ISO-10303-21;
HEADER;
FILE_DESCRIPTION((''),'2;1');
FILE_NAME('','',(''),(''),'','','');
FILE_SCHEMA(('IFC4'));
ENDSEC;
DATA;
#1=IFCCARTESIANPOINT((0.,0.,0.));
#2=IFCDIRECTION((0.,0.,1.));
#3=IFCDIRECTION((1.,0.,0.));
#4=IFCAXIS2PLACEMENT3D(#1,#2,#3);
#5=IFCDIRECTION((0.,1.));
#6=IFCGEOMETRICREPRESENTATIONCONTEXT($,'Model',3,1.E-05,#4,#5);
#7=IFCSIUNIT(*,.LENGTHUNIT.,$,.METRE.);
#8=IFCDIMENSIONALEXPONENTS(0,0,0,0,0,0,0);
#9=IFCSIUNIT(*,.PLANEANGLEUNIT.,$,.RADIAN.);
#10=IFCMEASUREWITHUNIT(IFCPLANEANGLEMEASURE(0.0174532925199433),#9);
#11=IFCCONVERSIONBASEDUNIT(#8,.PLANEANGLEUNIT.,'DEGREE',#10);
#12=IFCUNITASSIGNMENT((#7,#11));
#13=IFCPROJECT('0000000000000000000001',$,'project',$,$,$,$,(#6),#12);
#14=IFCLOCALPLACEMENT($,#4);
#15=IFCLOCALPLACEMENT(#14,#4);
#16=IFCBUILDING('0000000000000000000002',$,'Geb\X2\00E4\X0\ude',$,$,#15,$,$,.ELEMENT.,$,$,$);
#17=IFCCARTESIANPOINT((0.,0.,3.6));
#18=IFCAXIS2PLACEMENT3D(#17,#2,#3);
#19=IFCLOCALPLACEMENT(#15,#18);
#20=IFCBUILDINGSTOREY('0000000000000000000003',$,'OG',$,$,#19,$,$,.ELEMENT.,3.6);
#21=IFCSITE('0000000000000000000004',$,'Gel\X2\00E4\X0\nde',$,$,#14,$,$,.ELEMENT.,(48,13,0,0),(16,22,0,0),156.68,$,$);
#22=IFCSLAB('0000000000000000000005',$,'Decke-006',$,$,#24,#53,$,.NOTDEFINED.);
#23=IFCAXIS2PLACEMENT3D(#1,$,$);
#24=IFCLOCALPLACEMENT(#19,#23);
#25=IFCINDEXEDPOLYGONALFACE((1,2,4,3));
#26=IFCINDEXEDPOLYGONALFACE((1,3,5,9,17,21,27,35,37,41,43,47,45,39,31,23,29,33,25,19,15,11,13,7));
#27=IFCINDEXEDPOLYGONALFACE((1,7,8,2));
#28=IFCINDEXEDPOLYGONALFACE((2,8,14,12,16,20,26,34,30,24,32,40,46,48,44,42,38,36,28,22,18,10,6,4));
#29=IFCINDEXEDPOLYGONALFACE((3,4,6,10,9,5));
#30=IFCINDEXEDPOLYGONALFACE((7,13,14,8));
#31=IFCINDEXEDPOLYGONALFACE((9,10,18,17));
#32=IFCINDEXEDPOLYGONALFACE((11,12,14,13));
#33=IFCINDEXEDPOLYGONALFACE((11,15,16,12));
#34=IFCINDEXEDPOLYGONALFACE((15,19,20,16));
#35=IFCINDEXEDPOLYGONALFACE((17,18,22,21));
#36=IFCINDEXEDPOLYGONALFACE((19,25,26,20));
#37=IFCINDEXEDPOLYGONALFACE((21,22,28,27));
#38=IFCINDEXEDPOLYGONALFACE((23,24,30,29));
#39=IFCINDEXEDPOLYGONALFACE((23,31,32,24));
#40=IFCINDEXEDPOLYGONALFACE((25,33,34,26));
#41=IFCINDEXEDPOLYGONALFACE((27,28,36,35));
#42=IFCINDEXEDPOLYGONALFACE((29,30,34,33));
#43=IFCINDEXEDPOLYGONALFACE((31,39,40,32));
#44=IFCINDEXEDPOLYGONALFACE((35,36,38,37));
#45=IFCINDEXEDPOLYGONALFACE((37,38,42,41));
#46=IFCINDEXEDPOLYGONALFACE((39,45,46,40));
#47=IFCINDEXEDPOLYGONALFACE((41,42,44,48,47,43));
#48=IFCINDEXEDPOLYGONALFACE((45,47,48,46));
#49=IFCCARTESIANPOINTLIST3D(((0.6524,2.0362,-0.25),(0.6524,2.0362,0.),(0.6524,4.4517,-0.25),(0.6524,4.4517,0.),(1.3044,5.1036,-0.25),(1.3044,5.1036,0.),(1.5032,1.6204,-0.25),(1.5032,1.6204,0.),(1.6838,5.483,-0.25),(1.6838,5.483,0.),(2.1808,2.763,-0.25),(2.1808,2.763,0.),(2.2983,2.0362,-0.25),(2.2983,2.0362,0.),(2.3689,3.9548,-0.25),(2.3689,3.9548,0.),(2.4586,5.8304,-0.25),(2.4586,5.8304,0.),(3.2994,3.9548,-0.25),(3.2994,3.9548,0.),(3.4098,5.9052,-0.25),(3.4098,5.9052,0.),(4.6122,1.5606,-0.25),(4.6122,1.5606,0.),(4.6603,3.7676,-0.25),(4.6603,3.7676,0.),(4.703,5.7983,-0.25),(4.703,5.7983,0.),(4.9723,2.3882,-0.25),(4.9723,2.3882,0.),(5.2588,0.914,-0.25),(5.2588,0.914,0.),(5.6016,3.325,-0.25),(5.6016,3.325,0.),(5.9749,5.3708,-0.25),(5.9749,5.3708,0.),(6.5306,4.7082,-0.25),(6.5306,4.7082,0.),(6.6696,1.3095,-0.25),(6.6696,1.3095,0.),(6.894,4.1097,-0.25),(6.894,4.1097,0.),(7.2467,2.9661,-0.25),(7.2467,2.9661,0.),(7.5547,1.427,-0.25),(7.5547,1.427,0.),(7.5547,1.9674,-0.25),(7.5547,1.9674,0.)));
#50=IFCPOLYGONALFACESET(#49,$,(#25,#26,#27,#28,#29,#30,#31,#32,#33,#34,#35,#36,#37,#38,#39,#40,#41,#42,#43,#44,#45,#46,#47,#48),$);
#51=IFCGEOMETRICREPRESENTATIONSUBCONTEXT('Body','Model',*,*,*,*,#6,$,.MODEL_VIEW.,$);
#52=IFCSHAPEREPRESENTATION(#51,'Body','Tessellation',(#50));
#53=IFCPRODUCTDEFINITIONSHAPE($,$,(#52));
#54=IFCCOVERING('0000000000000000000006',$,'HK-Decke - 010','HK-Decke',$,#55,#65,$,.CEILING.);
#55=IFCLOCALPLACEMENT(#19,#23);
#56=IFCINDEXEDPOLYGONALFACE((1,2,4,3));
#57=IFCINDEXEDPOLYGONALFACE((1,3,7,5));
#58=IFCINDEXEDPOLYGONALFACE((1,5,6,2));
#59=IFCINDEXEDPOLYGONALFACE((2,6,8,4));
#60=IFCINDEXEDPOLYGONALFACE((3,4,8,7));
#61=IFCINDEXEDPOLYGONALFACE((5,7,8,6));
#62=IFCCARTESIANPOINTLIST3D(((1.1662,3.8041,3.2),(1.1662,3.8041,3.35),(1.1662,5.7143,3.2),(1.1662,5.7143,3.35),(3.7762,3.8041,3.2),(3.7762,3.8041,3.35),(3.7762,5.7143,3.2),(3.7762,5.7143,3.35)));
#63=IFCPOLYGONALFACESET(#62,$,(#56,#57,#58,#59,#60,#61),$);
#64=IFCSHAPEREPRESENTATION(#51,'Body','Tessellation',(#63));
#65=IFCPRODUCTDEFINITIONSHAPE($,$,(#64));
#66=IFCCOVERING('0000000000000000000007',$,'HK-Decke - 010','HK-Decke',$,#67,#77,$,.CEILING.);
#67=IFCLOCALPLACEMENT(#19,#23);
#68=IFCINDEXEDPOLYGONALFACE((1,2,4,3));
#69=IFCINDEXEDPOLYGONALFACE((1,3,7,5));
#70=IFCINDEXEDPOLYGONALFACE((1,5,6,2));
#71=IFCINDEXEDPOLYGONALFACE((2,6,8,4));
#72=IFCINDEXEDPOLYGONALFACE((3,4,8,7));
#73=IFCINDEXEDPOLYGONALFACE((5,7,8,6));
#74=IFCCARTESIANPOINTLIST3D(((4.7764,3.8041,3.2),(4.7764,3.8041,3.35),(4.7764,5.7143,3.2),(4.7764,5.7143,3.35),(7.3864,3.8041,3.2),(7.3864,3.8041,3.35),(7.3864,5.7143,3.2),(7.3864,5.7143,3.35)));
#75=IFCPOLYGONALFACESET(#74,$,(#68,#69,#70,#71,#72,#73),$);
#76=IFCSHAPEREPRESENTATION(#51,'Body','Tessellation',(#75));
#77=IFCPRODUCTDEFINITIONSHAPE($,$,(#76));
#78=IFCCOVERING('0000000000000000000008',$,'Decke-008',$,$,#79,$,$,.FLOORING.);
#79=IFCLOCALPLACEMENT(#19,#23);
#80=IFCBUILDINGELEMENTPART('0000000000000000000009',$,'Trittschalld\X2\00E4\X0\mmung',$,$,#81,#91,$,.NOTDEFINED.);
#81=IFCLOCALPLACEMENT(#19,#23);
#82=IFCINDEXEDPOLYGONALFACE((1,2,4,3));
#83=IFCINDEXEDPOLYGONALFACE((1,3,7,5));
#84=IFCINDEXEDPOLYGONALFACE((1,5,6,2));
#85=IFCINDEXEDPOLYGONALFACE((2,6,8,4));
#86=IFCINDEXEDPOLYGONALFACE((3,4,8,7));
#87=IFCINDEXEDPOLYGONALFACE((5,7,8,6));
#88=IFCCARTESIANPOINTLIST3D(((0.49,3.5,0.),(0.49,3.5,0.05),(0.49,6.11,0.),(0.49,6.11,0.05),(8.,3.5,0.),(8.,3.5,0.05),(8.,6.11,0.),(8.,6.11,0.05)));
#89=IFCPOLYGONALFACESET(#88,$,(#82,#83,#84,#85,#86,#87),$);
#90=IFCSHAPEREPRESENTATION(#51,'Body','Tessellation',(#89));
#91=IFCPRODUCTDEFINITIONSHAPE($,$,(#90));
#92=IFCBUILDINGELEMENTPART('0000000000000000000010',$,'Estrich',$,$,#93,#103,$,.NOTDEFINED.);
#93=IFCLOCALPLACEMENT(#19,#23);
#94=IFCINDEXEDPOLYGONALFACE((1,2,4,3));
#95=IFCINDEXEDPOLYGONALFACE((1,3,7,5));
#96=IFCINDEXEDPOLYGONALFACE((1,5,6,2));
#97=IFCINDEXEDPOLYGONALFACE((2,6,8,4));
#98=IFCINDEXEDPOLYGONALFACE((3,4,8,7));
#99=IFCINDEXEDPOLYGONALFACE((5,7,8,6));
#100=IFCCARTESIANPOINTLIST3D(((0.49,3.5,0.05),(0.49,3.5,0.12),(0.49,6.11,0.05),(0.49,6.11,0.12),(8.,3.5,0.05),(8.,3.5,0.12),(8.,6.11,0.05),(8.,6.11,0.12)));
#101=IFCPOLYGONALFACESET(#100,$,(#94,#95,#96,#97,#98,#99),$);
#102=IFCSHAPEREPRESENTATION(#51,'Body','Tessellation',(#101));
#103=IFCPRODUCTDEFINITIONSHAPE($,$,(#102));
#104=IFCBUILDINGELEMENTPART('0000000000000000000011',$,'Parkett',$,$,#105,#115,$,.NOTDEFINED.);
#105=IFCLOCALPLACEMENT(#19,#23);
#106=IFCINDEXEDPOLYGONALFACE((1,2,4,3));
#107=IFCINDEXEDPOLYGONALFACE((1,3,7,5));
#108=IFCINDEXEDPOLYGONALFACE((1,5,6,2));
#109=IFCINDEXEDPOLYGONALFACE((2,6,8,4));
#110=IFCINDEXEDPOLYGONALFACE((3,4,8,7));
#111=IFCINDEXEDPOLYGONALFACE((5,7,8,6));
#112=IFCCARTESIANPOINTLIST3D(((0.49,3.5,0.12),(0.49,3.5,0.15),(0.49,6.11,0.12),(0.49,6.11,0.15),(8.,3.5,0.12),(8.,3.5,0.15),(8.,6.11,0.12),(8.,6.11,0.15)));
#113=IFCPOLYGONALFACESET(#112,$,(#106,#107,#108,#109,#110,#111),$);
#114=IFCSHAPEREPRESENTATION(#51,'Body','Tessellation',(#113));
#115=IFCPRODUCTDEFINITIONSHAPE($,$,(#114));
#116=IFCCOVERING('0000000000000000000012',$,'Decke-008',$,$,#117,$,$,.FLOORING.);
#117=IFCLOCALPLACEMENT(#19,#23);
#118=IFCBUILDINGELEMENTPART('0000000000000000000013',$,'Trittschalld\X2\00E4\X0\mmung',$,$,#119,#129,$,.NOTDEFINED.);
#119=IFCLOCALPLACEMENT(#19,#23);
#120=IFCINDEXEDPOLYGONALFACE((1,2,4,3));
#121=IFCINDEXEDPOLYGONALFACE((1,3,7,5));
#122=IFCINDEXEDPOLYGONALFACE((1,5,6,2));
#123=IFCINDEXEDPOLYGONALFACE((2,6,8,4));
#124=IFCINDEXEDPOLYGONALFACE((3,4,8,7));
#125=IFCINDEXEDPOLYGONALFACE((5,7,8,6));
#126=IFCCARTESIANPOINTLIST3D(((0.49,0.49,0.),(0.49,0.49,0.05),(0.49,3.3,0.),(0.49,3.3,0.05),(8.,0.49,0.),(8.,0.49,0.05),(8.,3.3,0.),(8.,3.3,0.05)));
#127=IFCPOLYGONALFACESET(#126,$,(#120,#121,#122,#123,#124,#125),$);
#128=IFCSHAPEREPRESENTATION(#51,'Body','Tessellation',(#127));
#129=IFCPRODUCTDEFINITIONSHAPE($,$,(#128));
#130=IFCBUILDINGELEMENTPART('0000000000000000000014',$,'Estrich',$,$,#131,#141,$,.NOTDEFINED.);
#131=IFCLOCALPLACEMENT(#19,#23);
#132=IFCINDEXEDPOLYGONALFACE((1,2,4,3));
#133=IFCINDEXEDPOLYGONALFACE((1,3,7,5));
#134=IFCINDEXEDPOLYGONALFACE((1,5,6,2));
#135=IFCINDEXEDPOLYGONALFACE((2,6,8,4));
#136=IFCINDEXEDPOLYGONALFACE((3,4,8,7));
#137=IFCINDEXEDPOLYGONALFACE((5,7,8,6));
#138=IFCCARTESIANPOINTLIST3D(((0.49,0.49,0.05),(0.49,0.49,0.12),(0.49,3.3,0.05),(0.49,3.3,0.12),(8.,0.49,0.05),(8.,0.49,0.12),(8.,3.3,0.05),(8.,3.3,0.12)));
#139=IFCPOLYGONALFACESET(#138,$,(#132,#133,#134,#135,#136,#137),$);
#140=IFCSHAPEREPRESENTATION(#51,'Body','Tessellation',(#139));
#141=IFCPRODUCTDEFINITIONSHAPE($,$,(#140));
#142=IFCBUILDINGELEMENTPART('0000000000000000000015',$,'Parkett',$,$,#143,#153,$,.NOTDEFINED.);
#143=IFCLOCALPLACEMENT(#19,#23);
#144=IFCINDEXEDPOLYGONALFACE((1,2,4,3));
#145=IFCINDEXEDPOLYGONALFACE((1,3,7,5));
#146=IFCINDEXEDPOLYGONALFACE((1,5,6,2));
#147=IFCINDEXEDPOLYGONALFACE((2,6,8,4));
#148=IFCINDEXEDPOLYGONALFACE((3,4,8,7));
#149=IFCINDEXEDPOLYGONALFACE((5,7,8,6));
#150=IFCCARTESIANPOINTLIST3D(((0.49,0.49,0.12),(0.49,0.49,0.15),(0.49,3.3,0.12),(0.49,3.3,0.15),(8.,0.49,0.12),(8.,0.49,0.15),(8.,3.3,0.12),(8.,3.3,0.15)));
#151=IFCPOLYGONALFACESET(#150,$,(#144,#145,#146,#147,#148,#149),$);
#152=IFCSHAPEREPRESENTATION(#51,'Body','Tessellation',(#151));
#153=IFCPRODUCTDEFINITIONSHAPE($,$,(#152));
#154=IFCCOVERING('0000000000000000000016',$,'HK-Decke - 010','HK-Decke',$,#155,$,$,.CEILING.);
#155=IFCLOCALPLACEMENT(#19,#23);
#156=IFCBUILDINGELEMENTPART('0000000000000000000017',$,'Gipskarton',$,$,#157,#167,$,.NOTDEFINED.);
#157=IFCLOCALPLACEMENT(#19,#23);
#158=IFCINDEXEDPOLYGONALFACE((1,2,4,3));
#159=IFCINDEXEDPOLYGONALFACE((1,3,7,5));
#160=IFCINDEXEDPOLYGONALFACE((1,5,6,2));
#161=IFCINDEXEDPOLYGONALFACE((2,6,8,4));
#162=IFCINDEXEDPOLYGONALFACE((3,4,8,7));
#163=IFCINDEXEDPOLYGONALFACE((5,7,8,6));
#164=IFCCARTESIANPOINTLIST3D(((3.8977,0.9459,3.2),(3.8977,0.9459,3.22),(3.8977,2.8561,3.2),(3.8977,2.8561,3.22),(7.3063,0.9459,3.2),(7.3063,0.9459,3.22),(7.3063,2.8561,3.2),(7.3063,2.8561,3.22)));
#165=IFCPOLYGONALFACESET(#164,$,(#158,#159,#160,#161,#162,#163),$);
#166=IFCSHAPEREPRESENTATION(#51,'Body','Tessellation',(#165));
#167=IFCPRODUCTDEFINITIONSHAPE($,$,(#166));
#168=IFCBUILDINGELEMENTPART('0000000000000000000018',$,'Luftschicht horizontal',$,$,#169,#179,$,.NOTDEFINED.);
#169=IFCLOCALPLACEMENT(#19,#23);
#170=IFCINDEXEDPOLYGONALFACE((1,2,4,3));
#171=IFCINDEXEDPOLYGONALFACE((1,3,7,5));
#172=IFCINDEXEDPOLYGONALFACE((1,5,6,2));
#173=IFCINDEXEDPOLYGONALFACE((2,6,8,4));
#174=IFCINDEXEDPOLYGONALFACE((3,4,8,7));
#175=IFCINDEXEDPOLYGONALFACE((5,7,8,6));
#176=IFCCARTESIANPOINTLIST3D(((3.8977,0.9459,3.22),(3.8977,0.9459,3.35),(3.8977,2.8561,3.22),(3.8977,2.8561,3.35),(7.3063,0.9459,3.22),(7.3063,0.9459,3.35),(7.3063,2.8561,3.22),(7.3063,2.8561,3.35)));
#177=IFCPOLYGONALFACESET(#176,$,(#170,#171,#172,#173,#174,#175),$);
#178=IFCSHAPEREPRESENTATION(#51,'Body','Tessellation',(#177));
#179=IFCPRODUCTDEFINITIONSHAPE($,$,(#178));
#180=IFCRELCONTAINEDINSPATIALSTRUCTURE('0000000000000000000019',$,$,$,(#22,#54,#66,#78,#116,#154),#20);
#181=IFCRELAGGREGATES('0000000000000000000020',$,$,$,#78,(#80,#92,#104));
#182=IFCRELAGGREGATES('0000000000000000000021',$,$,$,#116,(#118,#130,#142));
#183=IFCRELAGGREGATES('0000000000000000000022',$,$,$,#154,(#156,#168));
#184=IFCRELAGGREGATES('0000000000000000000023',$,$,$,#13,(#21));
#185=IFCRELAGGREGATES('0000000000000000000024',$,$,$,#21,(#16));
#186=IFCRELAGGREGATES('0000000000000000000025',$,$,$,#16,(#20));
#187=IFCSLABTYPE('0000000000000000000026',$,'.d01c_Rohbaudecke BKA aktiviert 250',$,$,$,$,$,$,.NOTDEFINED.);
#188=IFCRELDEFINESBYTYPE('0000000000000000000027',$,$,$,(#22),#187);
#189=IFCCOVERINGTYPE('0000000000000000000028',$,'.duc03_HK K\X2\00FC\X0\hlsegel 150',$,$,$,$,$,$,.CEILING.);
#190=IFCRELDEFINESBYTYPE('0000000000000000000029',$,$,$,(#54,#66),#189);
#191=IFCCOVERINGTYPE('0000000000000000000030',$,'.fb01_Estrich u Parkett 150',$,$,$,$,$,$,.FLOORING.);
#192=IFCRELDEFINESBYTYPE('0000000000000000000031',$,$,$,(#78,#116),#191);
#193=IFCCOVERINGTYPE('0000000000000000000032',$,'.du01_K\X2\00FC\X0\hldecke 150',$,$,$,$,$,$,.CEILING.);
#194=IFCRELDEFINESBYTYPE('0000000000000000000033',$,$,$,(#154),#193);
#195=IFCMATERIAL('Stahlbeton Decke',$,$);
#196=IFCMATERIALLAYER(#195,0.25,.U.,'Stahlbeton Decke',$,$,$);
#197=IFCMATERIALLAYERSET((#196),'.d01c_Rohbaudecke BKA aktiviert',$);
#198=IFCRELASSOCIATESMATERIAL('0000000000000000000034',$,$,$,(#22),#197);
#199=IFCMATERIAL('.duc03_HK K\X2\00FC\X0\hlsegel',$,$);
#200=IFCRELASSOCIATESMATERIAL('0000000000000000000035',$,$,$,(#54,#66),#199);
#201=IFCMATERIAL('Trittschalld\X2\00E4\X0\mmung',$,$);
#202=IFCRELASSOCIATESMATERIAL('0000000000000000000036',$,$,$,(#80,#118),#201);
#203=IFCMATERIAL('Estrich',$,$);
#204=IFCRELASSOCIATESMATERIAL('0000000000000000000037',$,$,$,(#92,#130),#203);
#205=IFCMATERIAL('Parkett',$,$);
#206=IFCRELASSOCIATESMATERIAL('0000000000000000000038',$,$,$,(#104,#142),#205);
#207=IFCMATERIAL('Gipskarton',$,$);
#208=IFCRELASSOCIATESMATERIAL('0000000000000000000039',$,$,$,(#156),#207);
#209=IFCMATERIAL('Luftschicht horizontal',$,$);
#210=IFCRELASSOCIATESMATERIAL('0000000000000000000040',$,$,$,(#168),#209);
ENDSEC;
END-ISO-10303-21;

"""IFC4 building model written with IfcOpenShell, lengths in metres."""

from ifc_helpers import new_model, entity, si_unit, converted_unit, direction, frame, origin_with_axes, place, context, subcontext, project, spatial, line, indexed_curve, outline, extrude, material, layer, layer_set, layer_usage, type_object, element, aggregate, save


model = new_model("IFC4")

# Units and contexts
model_context = context("Model", 3, precision=1e-05, world=origin_with_axes(), true_north=direction((0.0, 1.0)))
body_context = subcontext(model_context, "Body", "Model", "MODEL_VIEW")
ifc_project = project(units=[si_unit("LENGTHUNIT", "METRE"), converted_unit("PLANEANGLEUNIT", "DEGREE", entity("IfcPlaneAngleMeasure", 0.0174532925199433), si_unit("PLANEANGLEUNIT", "RADIAN"), dimensions=[0, 0, 0, 0, 0, 0, 0])], contexts=[model_context])

# Site, building, storey
site_placement = place(None, origin_with_axes())
site = spatial("IfcSite", under=ifc_project, at=site_placement, Name="Gelände", CompositionType="ELEMENT", RefLatitude=(48, 13, 0, 0), RefLongitude=(16, 22, 0, 0), RefElevation=156.68)
building_placement = place(site_placement, origin_with_axes())
building = spatial("IfcBuilding", under=site, at=building_placement, Name="Gebäude", CompositionType="ELEMENT")
storey_placement = place(building_placement, frame((0.0, 0.0, 3.6), z_axis=(0.0, 0.0, 1.0), x_axis=(1.0, 0.0, 0.0)))
storey = spatial("IfcBuildingStorey", under=building, at=storey_placement, Name="OG", CompositionType="ELEMENT", Elevation=3.6)

# Slab
ifc_material_1 = material(Name="Stahlbeton Decke")
ifc_layer = layer(ifc_material_1, 0.25, ventilated="UNKNOWN", Name="Stahlbeton Decke")
ifc_layer_set = layer_set([ifc_layer], Name=".d01c_Rohbaudecke BKA aktiviert")
ifc_layer_usage = layer_usage(ifc_layer_set, "AXIS3", "NEGATIVE", 0.25)
slab_type = type_object("IfcSlabType", Name=".d01c_Rohbaudecke BKA aktiviert 250", PredefinedType="NOTDEFINED")
slab_placement = place(storey_placement, frame((1.3044, 5.1036, 0.0), z_axis=(0.0, 0.0, 1.0), x_axis=(1.0, 0.0, 0.0)))
element("IfcSlab", 1, at=slab_placement, inside=storey, type_object=slab_type, material=ifc_layer_usage, Name="Decke-006", PredefinedType="NOTDEFINED", context=body_context, shape_type="SweptSolid", body=[
    extrude(outline(indexed_curve([(0.0, 0.0), (-0.6519, -0.6519), (-0.6519, -3.0674), (0.1988, -3.4832), (0.994, -3.0674), (0.8764, -2.3406), (1.0645, -1.1488), (1.9951, -1.1488), (3.3559, -1.336), (4.2972, -1.7786), (3.6679, -2.7155), (3.3078, -3.543), (3.9544, -4.1896), (5.3652, -3.7941), (6.2503, -3.6766), (6.2503, -3.1362), (5.9423, -2.1375), (5.5896, -0.994), (5.2263, -0.3954), (4.6705, 0.2672), (3.3987, 0.6947), (2.1055, 0.8016), (1.1543, 0.7268), (0.3794, 0.3794)], segments=[line(1, 2, 3, 4, 5, 6, 7, 8, 9, 10, 11, 12, 13, 14, 15, 16, 17, 18, 19, 20, 21, 22, 23, 24, 1)])), frame((0.0, 0.0, -0.25), z_axis=(0.0, 0.0, 1.0), x_axis=(1.0, 0.0, 0.0)), (0.0, 0.0, 1.0), 0.25),
])

# Coverings
ifc_material_2 = material(Name=".duc03_HK Kühlsegel")
covering_type_1 = type_object("IfcCoveringType", Name=".duc03_HK Kühlsegel 150", PredefinedType="CEILING")
for number, where, z_axis, x_axis, name in (
    (2, (1.1662, 5.7143, 3.35), (0.0, 0.0, 1.0), (1.0, 0.0, 0.0), "HK-Decke - 010"),
    (3, (4.7764, 5.7143, 3.35), (0.0, 0.0, 1.0), (1.0, 0.0, 0.0), "HK-Decke - 010"),
):
    element("IfcCovering", number, at=place(storey_placement, frame(where, z_axis=z_axis, x_axis=x_axis)), inside=storey, type_object=covering_type_1, material=ifc_material_2, Name=name, Description="HK-Decke", PredefinedType="CEILING", context=body_context, shape_type="SweptSolid", body=[
        extrude(outline(indexed_curve([(0.0, 0.0), (0.0, -1.9102), (2.61, -1.9102), (2.61, 0.0)], segments=[line(1, 2, 3, 4, 1)])), frame((0.0, 0.0, -0.15), z_axis=(0.0, 0.0, 1.0), x_axis=(1.0, 0.0, 0.0)), (0.0, 0.0, 1.0), 0.15),
    ])

# Coverings, building element parts
covering_type_2 = type_object("IfcCoveringType", Name=".fb01_Estrich u Parkett 150", PredefinedType="FLOORING")
covering_1_placement = place(storey_placement, frame((0.49, 3.5, 0.15), z_axis=(0.0, 0.0, 1.0), x_axis=(1.0, 0.0, 0.0)))
covering_1 = element("IfcCovering", 4, at=covering_1_placement, inside=storey, type_object=covering_type_2, Name="Decke-008", PredefinedType="FLOORING")
ifc_material_3 = material(Name="Trittschalldämmung")
building_element_part_1_placement = place(covering_1_placement, origin_with_axes())
building_element_part_1 = element("IfcBuildingElementPart", 5, at=building_element_part_1_placement, material=ifc_material_3, Name="Trittschalldämmung", PredefinedType="NOTDEFINED", context=body_context, shape_type="SweptSolid", body=[
    extrude(outline(indexed_curve([(0.0, 0.0), (7.51, 0.0), (7.51, 2.61), (0.0, 2.61)], segments=[line(1, 2, 3, 4, 1)])), frame((0.0, 0.0, -0.15), z_axis=(0.0, 0.0, 1.0), x_axis=(1.0, 0.0, 0.0)), (0.0, 0.0, 1.0), 0.05),
])
ifc_material_4 = material(Name="Estrich")
building_element_part_2_placement = place(covering_1_placement, origin_with_axes())
building_element_part_2 = element("IfcBuildingElementPart", 6, at=building_element_part_2_placement, material=ifc_material_4, Name="Estrich", PredefinedType="NOTDEFINED", context=body_context, shape_type="SweptSolid", body=[
    extrude(outline(indexed_curve([(0.0, 0.0), (7.51, 0.0), (7.51, 2.61), (0.0, 2.61)], segments=[line(1, 2, 3, 4, 1)])), frame((0.0, 0.0, -0.1), z_axis=(0.0, 0.0, 1.0), x_axis=(1.0, 0.0, 0.0)), (0.0, 0.0, 1.0), 0.07),
])
ifc_material_5 = material(Name="Parkett")
building_element_part_3_placement = place(covering_1_placement, origin_with_axes())
building_element_part_3 = element("IfcBuildingElementPart", 7, at=building_element_part_3_placement, material=ifc_material_5, Name="Parkett", PredefinedType="NOTDEFINED", context=body_context, shape_type="SweptSolid", body=[
    extrude(outline(indexed_curve([(0.0, 0.0), (7.51, 0.0), (7.51, 2.61), (0.0, 2.61)], segments=[line(1, 2, 3, 4, 1)])), frame((0.0, 0.0, -0.03), z_axis=(0.0, 0.0, 1.0), x_axis=(1.0, 0.0, 0.0)), (0.0, 0.0, 1.0), 0.03),
])
aggregate(covering_1, [building_element_part_1, building_element_part_2, building_element_part_3])
covering_2_placement = place(storey_placement, frame((0.49, 0.49, 0.15), z_axis=(0.0, 0.0, 1.0), x_axis=(1.0, 0.0, 0.0)))
covering_2 = element("IfcCovering", 8, at=covering_2_placement, inside=storey, type_object=covering_type_2, Name="Decke-008", PredefinedType="FLOORING")
building_element_part_4_placement = place(covering_2_placement, origin_with_axes())
building_element_part_4 = element("IfcBuildingElementPart", 9, at=building_element_part_4_placement, material=ifc_material_3, Name="Trittschalldämmung", PredefinedType="NOTDEFINED", context=body_context, shape_type="SweptSolid", body=[
    extrude(outline(indexed_curve([(0.0, 0.0), (7.51, 0.0), (7.51, 2.81), (0.0, 2.81)], segments=[line(1, 2, 3, 4, 1)])), frame((0.0, 0.0, -0.15), z_axis=(0.0, 0.0, 1.0), x_axis=(1.0, 0.0, 0.0)), (0.0, 0.0, 1.0), 0.05),
])
building_element_part_5_placement = place(covering_2_placement, origin_with_axes())
building_element_part_5 = element("IfcBuildingElementPart", 10, at=building_element_part_5_placement, material=ifc_material_4, Name="Estrich", PredefinedType="NOTDEFINED", context=body_context, shape_type="SweptSolid", body=[
    extrude(outline(indexed_curve([(0.0, 0.0), (7.51, 0.0), (7.51, 2.81), (0.0, 2.81)], segments=[line(1, 2, 3, 4, 1)])), frame((0.0, 0.0, -0.1), z_axis=(0.0, 0.0, 1.0), x_axis=(1.0, 0.0, 0.0)), (0.0, 0.0, 1.0), 0.07),
])
building_element_part_6_placement = place(covering_2_placement, origin_with_axes())
building_element_part_6 = element("IfcBuildingElementPart", 11, at=building_element_part_6_placement, material=ifc_material_5, Name="Parkett", PredefinedType="NOTDEFINED", context=body_context, shape_type="SweptSolid", body=[
    extrude(outline(indexed_curve([(0.0, 0.0), (7.51, 0.0), (7.51, 2.81), (0.0, 2.81)], segments=[line(1, 2, 3, 4, 1)])), frame((0.0, 0.0, -0.03), z_axis=(0.0, 0.0, 1.0), x_axis=(1.0, 0.0, 0.0)), (0.0, 0.0, 1.0), 0.03),
])
aggregate(covering_2, [building_element_part_4, building_element_part_5, building_element_part_6])
covering_type_3 = type_object("IfcCoveringType", Name=".du01_Kühldecke 150", PredefinedType="CEILING")
covering_3_placement = place(storey_placement, frame((3.8977, 2.8561, 3.35), z_axis=(0.0, 0.0, 1.0), x_axis=(1.0, 0.0, 0.0)))
covering_3 = element("IfcCovering", 12, at=covering_3_placement, inside=storey, type_object=covering_type_3, Name="HK-Decke - 010", Description="HK-Decke", PredefinedType="CEILING")
ifc_material_6 = material(Name="Gipskarton")
building_element_part_7_placement = place(covering_3_placement, origin_with_axes())
building_element_part_7 = element("IfcBuildingElementPart", 13, at=building_element_part_7_placement, material=ifc_material_6, Name="Gipskarton", PredefinedType="NOTDEFINED", context=body_context, shape_type="SweptSolid", body=[
    extrude(outline(indexed_curve([(0.0, 0.0), (0.0, -1.9102), (3.4085, -1.9102), (3.4085, 0.0)], segments=[line(1, 2, 3, 4, 1)])), frame((0.0, 0.0, -0.15), z_axis=(0.0, 0.0, 1.0), x_axis=(1.0, 0.0, 0.0)), (0.0, 0.0, 1.0), 0.02),
])
ifc_material_7 = material(Name="Luftschicht horizontal")
building_element_part_8_placement = place(covering_3_placement, origin_with_axes())
building_element_part_8 = element("IfcBuildingElementPart", 14, at=building_element_part_8_placement, material=ifc_material_7, Name="Luftschicht horizontal", PredefinedType="NOTDEFINED", context=body_context, shape_type="SweptSolid", body=[
    extrude(outline(indexed_curve([(0.0, 0.0), (0.0, -1.9102), (3.4085, -1.9102), (3.4085, 0.0)], segments=[line(1, 2, 3, 4, 1)])), frame((0.0, 0.0, -0.13), z_axis=(0.0, 0.0, 1.0), x_axis=(1.0, 0.0, 0.0)), (0.0, 0.0, 1.0), 0.13),
])
aggregate(covering_3, [building_element_part_7, building_element_part_8])

save(model, "model.ifc")
